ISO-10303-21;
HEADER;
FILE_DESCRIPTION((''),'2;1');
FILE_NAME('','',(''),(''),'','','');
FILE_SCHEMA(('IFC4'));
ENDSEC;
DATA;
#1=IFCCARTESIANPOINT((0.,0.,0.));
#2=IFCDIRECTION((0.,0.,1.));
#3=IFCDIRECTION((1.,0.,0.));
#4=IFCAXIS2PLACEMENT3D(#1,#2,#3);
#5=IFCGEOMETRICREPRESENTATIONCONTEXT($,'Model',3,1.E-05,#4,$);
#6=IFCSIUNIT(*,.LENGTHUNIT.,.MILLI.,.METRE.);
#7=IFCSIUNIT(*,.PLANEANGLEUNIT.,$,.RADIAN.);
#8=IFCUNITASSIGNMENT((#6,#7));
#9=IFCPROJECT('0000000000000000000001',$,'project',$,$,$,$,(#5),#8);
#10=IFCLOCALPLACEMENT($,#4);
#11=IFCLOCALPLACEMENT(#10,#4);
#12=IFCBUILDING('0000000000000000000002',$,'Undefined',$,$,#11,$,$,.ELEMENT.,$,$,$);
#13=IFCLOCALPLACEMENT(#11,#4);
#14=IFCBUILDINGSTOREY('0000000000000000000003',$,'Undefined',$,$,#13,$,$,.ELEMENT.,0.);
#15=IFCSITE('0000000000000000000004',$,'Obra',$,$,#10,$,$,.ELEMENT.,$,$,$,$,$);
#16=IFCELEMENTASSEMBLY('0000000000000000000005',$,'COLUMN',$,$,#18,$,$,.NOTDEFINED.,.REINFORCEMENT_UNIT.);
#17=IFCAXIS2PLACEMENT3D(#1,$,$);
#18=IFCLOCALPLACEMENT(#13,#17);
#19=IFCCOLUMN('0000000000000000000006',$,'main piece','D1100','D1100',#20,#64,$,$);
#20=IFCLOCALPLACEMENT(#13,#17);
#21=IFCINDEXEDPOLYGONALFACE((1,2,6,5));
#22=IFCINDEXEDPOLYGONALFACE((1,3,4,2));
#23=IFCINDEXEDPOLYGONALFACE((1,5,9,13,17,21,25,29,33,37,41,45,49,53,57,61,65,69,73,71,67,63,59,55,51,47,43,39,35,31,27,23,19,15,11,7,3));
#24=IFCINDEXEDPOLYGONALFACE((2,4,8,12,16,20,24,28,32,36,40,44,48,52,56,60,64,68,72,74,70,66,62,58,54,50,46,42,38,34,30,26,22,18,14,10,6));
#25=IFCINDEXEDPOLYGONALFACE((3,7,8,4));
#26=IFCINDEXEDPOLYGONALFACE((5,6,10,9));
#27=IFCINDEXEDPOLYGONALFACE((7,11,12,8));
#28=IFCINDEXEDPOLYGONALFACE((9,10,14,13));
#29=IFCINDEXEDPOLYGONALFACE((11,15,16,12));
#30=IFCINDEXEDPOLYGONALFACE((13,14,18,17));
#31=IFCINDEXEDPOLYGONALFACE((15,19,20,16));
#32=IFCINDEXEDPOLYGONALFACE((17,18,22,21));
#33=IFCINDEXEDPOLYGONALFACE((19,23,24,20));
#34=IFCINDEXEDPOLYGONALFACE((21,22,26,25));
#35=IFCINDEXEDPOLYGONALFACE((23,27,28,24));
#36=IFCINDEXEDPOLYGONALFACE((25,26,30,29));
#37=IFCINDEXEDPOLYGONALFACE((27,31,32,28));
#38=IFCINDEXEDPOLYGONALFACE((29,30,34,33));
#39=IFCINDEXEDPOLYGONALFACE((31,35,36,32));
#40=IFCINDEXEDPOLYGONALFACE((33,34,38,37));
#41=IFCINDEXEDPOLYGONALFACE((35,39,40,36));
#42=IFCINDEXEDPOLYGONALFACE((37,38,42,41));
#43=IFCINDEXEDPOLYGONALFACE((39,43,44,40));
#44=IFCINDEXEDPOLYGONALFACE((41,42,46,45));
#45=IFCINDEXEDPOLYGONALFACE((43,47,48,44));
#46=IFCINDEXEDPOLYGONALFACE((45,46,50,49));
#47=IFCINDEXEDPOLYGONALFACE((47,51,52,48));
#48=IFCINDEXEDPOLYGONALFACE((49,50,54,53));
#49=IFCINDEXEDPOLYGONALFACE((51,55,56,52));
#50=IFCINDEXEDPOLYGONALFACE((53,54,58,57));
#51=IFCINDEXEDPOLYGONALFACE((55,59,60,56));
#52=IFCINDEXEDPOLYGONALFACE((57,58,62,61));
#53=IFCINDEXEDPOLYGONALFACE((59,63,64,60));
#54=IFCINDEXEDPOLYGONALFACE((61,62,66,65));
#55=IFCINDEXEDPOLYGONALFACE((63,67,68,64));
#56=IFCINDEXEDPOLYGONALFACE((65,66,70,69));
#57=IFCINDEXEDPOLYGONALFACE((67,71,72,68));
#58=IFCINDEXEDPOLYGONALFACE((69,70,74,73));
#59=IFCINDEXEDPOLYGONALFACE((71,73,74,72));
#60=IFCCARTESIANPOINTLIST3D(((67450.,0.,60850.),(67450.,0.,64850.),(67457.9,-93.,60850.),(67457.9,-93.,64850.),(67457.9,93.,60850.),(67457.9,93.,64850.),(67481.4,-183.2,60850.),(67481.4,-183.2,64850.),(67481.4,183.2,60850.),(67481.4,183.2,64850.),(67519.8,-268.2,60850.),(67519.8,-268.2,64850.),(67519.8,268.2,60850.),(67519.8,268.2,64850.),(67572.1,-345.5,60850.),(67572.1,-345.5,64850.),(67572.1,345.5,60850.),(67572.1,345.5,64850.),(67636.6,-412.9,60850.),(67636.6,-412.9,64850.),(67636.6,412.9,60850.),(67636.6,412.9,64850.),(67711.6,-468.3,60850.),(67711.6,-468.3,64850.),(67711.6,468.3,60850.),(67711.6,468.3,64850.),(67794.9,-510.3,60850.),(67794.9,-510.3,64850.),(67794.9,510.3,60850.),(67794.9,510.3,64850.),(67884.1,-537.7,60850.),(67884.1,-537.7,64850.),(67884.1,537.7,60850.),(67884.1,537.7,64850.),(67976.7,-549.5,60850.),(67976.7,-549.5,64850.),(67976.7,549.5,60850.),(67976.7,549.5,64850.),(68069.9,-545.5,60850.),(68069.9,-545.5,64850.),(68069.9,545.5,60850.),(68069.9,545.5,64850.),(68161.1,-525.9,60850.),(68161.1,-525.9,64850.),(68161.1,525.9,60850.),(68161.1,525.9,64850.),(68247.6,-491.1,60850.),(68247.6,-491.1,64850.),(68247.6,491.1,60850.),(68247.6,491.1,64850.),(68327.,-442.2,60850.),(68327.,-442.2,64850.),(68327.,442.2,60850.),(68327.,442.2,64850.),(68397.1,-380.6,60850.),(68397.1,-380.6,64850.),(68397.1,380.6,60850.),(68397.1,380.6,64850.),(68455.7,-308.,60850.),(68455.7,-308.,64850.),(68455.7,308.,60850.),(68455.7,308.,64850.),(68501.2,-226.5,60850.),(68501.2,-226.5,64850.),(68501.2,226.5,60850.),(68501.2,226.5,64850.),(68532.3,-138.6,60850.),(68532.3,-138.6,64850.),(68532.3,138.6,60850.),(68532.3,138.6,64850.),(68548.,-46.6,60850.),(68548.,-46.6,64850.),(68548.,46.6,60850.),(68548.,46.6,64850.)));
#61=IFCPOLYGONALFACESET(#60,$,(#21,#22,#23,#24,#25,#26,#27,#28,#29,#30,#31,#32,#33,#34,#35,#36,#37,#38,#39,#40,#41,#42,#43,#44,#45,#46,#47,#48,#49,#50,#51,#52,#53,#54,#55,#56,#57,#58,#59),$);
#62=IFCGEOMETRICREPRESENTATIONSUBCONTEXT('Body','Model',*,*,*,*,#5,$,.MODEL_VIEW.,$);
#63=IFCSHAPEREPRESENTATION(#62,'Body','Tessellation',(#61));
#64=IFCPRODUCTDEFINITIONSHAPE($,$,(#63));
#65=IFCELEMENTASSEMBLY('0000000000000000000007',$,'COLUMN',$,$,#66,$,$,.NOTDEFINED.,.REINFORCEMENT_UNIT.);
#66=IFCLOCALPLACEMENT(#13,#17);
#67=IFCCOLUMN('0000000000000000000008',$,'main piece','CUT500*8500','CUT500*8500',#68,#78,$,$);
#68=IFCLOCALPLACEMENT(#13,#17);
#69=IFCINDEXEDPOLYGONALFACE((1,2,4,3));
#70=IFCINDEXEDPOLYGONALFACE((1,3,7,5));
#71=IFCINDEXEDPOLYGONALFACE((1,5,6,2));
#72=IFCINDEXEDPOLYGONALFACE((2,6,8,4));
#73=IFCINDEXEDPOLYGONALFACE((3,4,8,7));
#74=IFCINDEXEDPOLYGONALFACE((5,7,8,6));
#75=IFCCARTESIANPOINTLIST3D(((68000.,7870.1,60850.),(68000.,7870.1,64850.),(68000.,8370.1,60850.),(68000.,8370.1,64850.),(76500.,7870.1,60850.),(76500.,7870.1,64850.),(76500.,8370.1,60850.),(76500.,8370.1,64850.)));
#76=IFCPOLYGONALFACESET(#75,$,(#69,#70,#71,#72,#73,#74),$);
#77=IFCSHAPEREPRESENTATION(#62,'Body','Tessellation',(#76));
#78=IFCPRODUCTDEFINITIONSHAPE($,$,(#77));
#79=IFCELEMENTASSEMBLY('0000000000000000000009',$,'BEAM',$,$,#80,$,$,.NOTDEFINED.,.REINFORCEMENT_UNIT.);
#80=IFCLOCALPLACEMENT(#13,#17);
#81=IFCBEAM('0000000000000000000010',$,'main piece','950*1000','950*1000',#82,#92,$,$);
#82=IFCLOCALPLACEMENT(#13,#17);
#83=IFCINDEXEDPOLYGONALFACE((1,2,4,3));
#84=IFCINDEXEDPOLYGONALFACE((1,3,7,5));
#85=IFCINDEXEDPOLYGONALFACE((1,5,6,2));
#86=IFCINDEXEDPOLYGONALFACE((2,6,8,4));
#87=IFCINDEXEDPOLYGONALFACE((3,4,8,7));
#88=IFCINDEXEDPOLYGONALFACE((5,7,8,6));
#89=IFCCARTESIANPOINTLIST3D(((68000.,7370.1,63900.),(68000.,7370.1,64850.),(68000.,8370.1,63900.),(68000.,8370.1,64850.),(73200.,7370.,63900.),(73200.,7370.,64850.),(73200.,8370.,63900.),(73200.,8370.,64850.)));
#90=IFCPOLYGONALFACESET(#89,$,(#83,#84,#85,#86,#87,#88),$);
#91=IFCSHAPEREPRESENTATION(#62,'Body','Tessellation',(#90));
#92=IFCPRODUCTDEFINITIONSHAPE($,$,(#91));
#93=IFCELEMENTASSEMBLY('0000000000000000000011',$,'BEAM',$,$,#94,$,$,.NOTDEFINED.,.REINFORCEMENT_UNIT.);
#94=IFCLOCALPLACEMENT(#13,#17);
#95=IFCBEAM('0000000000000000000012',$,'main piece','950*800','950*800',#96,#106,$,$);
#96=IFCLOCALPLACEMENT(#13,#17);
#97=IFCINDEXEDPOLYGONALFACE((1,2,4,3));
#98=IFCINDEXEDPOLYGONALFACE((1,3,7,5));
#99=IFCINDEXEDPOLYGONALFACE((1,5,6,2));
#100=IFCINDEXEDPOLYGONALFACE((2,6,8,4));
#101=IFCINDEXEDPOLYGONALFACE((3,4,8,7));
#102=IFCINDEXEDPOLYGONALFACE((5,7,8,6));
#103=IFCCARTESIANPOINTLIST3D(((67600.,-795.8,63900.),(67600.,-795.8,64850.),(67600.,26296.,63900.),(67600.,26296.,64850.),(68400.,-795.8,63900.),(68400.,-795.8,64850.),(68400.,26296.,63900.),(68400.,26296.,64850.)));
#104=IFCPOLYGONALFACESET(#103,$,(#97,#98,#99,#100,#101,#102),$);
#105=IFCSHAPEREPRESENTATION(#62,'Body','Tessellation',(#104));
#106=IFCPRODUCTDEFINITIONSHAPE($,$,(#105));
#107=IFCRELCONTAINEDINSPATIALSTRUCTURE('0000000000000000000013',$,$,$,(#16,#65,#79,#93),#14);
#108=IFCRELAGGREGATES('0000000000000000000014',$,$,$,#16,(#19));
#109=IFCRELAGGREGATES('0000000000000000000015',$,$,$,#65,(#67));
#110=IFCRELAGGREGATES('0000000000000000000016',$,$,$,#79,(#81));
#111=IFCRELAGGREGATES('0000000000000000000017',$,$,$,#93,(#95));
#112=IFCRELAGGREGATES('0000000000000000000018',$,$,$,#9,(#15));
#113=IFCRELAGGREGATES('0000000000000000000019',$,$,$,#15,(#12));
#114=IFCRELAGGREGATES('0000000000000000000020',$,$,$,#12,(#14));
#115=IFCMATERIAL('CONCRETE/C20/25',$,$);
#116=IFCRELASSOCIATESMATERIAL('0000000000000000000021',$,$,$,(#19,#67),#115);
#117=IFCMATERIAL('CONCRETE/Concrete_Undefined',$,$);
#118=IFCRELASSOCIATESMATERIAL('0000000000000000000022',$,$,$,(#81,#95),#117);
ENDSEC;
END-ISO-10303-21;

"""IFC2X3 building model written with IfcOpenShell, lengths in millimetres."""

from ifc_helpers import new_model, si_unit, frame, origin_with_axes, origin_2d_with_axis, place, context, subcontext, project, spatial, rectangle, circle, extrude, material, element, aggregate, save


model = new_model("IFC2X3")

# Units and contexts
model_context = context("Model", 3, precision=1e-05, world=origin_with_axes())
body_context = subcontext(model_context, "Body", "Model", "MODEL_VIEW")
ifc_project = project(units=[si_unit("LENGTHUNIT", "METRE", prefix="MILLI"), si_unit("PLANEANGLEUNIT", "RADIAN")], contexts=[model_context])

# Site, building, storey
site_placement = place(None, origin_with_axes())
site = spatial("IfcSite", under=ifc_project, at=site_placement, Name="Obra", CompositionType="ELEMENT")
building_placement = place(site_placement, origin_with_axes())
building = spatial("IfcBuilding", under=site, at=building_placement, Name="Undefined", CompositionType="ELEMENT")
storey_placement = place(building_placement, origin_with_axes())
storey = spatial("IfcBuildingStorey", under=building, at=storey_placement, Name="Undefined", CompositionType="ELEMENT", Elevation=0.0)

# Element assemblies, columns
assembly_1_placement = place(storey_placement, origin_with_axes())
assembly_1 = element("IfcElementAssembly", 1, at=assembly_1_placement, inside=storey, Name="COLUMN", AssemblyPlace="NOTDEFINED", PredefinedType="REINFORCEMENT_UNIT")
ifc_material_1 = material(Name="CONCRETE/C20/25")
column_1_placement = place(assembly_1_placement, frame((68000.0, 0.0, 60850.0), z_axis=(0.0, 0.0, 1.0), x_axis=(0.0, 1.0, 0.0)))
column_1 = element("IfcColumn", 2, at=column_1_placement, material=ifc_material_1, Name="main piece", Description="D1100", ObjectType="D1100", context=body_context, shape_type="SweptSolid", body=[
    extrude(circle(Radius=550.0, at=origin_2d_with_axis()), frame((0.0, 0.0, 4000.0), z_axis=(0.0, 0.0, -1.0), x_axis=(0.0, 1.0, 0.0)), (0.0, 0.0, 1.0), 4000.0),
])
aggregate(assembly_1, [column_1])
assembly_2_placement = place(storey_placement, origin_with_axes())
assembly_2 = element("IfcElementAssembly", 3, at=assembly_2_placement, inside=storey, Name="COLUMN", AssemblyPlace="NOTDEFINED", PredefinedType="REINFORCEMENT_UNIT")
column_2_placement = place(assembly_2_placement, frame((72250.0, 8120.1, 60850.0), z_axis=(0.0, 0.0, 1.0), x_axis=(-1.0, 0.0, 0.0)))
column_2 = element("IfcColumn", 4, at=column_2_placement, material=ifc_material_1, Name="main piece", Description="CUT500*8500", ObjectType="CUT500*8500", context=body_context, shape_type="SweptSolid", body=[
    extrude(rectangle(XDim=500.0, YDim=8500.0, at=origin_2d_with_axis()), frame((0.0, 0.0, 4000.0), z_axis=(0.0, 0.0, -1.0), x_axis=(0.0, 1.0, 0.0)), (0.0, 0.0, 1.0), 4000.0),
])
aggregate(assembly_2, [column_2])

# Element assemblies, beams
assembly_3_placement = place(storey_placement, origin_with_axes())
assembly_3 = element("IfcElementAssembly", 5, at=assembly_3_placement, inside=storey, Name="BEAM", AssemblyPlace="NOTDEFINED", PredefinedType="REINFORCEMENT_UNIT")
ifc_material_2 = material(Name="CONCRETE/Concrete_Undefined")
beam_1_placement = place(assembly_3_placement, frame((68000.0, 7870.1, 64375.0), z_axis=(0.0, 0.0, 1.0), x_axis=(1.0, -0.000019, 0.0)))
beam_1 = element("IfcBeam", 6, at=beam_1_placement, material=ifc_material_2, Name="main piece", Description="950*1000", ObjectType="950*1000", context=body_context, shape_type="SweptSolid", body=[
    extrude(rectangle(XDim=1000.0, YDim=950.0, at=origin_2d_with_axis()), frame((5200.0, 0.0, 0.0), z_axis=(-1.0, 0.0, 0.0), x_axis=(0.0, -1.0, 0.0)), (0.0, 0.0, 1.0), 5200.0),
])
aggregate(assembly_3, [beam_1])
assembly_4_placement = place(storey_placement, origin_with_axes())
assembly_4 = element("IfcElementAssembly", 7, at=assembly_4_placement, inside=storey, Name="BEAM", AssemblyPlace="NOTDEFINED", PredefinedType="REINFORCEMENT_UNIT")
beam_2_placement = place(assembly_4_placement, frame((68000.0, -795.8, 64375.0), z_axis=(0.0, 0.0, 1.0), x_axis=(0.0, 1.0, 0.0)))
beam_2 = element("IfcBeam", 8, at=beam_2_placement, material=ifc_material_2, Name="main piece", Description="950*800", ObjectType="950*800", context=body_context, shape_type="SweptSolid", body=[
    extrude(rectangle(XDim=800.0, YDim=950.0, at=origin_2d_with_axis()), frame((27091.8, 0.0, 0.0), z_axis=(-1.0, 0.0, 0.0), x_axis=(0.0, -1.0, 0.0)), (0.0, 0.0, 1.0), 27091.8),
])
aggregate(assembly_4, [beam_2])

save(model, "model.ifc")
